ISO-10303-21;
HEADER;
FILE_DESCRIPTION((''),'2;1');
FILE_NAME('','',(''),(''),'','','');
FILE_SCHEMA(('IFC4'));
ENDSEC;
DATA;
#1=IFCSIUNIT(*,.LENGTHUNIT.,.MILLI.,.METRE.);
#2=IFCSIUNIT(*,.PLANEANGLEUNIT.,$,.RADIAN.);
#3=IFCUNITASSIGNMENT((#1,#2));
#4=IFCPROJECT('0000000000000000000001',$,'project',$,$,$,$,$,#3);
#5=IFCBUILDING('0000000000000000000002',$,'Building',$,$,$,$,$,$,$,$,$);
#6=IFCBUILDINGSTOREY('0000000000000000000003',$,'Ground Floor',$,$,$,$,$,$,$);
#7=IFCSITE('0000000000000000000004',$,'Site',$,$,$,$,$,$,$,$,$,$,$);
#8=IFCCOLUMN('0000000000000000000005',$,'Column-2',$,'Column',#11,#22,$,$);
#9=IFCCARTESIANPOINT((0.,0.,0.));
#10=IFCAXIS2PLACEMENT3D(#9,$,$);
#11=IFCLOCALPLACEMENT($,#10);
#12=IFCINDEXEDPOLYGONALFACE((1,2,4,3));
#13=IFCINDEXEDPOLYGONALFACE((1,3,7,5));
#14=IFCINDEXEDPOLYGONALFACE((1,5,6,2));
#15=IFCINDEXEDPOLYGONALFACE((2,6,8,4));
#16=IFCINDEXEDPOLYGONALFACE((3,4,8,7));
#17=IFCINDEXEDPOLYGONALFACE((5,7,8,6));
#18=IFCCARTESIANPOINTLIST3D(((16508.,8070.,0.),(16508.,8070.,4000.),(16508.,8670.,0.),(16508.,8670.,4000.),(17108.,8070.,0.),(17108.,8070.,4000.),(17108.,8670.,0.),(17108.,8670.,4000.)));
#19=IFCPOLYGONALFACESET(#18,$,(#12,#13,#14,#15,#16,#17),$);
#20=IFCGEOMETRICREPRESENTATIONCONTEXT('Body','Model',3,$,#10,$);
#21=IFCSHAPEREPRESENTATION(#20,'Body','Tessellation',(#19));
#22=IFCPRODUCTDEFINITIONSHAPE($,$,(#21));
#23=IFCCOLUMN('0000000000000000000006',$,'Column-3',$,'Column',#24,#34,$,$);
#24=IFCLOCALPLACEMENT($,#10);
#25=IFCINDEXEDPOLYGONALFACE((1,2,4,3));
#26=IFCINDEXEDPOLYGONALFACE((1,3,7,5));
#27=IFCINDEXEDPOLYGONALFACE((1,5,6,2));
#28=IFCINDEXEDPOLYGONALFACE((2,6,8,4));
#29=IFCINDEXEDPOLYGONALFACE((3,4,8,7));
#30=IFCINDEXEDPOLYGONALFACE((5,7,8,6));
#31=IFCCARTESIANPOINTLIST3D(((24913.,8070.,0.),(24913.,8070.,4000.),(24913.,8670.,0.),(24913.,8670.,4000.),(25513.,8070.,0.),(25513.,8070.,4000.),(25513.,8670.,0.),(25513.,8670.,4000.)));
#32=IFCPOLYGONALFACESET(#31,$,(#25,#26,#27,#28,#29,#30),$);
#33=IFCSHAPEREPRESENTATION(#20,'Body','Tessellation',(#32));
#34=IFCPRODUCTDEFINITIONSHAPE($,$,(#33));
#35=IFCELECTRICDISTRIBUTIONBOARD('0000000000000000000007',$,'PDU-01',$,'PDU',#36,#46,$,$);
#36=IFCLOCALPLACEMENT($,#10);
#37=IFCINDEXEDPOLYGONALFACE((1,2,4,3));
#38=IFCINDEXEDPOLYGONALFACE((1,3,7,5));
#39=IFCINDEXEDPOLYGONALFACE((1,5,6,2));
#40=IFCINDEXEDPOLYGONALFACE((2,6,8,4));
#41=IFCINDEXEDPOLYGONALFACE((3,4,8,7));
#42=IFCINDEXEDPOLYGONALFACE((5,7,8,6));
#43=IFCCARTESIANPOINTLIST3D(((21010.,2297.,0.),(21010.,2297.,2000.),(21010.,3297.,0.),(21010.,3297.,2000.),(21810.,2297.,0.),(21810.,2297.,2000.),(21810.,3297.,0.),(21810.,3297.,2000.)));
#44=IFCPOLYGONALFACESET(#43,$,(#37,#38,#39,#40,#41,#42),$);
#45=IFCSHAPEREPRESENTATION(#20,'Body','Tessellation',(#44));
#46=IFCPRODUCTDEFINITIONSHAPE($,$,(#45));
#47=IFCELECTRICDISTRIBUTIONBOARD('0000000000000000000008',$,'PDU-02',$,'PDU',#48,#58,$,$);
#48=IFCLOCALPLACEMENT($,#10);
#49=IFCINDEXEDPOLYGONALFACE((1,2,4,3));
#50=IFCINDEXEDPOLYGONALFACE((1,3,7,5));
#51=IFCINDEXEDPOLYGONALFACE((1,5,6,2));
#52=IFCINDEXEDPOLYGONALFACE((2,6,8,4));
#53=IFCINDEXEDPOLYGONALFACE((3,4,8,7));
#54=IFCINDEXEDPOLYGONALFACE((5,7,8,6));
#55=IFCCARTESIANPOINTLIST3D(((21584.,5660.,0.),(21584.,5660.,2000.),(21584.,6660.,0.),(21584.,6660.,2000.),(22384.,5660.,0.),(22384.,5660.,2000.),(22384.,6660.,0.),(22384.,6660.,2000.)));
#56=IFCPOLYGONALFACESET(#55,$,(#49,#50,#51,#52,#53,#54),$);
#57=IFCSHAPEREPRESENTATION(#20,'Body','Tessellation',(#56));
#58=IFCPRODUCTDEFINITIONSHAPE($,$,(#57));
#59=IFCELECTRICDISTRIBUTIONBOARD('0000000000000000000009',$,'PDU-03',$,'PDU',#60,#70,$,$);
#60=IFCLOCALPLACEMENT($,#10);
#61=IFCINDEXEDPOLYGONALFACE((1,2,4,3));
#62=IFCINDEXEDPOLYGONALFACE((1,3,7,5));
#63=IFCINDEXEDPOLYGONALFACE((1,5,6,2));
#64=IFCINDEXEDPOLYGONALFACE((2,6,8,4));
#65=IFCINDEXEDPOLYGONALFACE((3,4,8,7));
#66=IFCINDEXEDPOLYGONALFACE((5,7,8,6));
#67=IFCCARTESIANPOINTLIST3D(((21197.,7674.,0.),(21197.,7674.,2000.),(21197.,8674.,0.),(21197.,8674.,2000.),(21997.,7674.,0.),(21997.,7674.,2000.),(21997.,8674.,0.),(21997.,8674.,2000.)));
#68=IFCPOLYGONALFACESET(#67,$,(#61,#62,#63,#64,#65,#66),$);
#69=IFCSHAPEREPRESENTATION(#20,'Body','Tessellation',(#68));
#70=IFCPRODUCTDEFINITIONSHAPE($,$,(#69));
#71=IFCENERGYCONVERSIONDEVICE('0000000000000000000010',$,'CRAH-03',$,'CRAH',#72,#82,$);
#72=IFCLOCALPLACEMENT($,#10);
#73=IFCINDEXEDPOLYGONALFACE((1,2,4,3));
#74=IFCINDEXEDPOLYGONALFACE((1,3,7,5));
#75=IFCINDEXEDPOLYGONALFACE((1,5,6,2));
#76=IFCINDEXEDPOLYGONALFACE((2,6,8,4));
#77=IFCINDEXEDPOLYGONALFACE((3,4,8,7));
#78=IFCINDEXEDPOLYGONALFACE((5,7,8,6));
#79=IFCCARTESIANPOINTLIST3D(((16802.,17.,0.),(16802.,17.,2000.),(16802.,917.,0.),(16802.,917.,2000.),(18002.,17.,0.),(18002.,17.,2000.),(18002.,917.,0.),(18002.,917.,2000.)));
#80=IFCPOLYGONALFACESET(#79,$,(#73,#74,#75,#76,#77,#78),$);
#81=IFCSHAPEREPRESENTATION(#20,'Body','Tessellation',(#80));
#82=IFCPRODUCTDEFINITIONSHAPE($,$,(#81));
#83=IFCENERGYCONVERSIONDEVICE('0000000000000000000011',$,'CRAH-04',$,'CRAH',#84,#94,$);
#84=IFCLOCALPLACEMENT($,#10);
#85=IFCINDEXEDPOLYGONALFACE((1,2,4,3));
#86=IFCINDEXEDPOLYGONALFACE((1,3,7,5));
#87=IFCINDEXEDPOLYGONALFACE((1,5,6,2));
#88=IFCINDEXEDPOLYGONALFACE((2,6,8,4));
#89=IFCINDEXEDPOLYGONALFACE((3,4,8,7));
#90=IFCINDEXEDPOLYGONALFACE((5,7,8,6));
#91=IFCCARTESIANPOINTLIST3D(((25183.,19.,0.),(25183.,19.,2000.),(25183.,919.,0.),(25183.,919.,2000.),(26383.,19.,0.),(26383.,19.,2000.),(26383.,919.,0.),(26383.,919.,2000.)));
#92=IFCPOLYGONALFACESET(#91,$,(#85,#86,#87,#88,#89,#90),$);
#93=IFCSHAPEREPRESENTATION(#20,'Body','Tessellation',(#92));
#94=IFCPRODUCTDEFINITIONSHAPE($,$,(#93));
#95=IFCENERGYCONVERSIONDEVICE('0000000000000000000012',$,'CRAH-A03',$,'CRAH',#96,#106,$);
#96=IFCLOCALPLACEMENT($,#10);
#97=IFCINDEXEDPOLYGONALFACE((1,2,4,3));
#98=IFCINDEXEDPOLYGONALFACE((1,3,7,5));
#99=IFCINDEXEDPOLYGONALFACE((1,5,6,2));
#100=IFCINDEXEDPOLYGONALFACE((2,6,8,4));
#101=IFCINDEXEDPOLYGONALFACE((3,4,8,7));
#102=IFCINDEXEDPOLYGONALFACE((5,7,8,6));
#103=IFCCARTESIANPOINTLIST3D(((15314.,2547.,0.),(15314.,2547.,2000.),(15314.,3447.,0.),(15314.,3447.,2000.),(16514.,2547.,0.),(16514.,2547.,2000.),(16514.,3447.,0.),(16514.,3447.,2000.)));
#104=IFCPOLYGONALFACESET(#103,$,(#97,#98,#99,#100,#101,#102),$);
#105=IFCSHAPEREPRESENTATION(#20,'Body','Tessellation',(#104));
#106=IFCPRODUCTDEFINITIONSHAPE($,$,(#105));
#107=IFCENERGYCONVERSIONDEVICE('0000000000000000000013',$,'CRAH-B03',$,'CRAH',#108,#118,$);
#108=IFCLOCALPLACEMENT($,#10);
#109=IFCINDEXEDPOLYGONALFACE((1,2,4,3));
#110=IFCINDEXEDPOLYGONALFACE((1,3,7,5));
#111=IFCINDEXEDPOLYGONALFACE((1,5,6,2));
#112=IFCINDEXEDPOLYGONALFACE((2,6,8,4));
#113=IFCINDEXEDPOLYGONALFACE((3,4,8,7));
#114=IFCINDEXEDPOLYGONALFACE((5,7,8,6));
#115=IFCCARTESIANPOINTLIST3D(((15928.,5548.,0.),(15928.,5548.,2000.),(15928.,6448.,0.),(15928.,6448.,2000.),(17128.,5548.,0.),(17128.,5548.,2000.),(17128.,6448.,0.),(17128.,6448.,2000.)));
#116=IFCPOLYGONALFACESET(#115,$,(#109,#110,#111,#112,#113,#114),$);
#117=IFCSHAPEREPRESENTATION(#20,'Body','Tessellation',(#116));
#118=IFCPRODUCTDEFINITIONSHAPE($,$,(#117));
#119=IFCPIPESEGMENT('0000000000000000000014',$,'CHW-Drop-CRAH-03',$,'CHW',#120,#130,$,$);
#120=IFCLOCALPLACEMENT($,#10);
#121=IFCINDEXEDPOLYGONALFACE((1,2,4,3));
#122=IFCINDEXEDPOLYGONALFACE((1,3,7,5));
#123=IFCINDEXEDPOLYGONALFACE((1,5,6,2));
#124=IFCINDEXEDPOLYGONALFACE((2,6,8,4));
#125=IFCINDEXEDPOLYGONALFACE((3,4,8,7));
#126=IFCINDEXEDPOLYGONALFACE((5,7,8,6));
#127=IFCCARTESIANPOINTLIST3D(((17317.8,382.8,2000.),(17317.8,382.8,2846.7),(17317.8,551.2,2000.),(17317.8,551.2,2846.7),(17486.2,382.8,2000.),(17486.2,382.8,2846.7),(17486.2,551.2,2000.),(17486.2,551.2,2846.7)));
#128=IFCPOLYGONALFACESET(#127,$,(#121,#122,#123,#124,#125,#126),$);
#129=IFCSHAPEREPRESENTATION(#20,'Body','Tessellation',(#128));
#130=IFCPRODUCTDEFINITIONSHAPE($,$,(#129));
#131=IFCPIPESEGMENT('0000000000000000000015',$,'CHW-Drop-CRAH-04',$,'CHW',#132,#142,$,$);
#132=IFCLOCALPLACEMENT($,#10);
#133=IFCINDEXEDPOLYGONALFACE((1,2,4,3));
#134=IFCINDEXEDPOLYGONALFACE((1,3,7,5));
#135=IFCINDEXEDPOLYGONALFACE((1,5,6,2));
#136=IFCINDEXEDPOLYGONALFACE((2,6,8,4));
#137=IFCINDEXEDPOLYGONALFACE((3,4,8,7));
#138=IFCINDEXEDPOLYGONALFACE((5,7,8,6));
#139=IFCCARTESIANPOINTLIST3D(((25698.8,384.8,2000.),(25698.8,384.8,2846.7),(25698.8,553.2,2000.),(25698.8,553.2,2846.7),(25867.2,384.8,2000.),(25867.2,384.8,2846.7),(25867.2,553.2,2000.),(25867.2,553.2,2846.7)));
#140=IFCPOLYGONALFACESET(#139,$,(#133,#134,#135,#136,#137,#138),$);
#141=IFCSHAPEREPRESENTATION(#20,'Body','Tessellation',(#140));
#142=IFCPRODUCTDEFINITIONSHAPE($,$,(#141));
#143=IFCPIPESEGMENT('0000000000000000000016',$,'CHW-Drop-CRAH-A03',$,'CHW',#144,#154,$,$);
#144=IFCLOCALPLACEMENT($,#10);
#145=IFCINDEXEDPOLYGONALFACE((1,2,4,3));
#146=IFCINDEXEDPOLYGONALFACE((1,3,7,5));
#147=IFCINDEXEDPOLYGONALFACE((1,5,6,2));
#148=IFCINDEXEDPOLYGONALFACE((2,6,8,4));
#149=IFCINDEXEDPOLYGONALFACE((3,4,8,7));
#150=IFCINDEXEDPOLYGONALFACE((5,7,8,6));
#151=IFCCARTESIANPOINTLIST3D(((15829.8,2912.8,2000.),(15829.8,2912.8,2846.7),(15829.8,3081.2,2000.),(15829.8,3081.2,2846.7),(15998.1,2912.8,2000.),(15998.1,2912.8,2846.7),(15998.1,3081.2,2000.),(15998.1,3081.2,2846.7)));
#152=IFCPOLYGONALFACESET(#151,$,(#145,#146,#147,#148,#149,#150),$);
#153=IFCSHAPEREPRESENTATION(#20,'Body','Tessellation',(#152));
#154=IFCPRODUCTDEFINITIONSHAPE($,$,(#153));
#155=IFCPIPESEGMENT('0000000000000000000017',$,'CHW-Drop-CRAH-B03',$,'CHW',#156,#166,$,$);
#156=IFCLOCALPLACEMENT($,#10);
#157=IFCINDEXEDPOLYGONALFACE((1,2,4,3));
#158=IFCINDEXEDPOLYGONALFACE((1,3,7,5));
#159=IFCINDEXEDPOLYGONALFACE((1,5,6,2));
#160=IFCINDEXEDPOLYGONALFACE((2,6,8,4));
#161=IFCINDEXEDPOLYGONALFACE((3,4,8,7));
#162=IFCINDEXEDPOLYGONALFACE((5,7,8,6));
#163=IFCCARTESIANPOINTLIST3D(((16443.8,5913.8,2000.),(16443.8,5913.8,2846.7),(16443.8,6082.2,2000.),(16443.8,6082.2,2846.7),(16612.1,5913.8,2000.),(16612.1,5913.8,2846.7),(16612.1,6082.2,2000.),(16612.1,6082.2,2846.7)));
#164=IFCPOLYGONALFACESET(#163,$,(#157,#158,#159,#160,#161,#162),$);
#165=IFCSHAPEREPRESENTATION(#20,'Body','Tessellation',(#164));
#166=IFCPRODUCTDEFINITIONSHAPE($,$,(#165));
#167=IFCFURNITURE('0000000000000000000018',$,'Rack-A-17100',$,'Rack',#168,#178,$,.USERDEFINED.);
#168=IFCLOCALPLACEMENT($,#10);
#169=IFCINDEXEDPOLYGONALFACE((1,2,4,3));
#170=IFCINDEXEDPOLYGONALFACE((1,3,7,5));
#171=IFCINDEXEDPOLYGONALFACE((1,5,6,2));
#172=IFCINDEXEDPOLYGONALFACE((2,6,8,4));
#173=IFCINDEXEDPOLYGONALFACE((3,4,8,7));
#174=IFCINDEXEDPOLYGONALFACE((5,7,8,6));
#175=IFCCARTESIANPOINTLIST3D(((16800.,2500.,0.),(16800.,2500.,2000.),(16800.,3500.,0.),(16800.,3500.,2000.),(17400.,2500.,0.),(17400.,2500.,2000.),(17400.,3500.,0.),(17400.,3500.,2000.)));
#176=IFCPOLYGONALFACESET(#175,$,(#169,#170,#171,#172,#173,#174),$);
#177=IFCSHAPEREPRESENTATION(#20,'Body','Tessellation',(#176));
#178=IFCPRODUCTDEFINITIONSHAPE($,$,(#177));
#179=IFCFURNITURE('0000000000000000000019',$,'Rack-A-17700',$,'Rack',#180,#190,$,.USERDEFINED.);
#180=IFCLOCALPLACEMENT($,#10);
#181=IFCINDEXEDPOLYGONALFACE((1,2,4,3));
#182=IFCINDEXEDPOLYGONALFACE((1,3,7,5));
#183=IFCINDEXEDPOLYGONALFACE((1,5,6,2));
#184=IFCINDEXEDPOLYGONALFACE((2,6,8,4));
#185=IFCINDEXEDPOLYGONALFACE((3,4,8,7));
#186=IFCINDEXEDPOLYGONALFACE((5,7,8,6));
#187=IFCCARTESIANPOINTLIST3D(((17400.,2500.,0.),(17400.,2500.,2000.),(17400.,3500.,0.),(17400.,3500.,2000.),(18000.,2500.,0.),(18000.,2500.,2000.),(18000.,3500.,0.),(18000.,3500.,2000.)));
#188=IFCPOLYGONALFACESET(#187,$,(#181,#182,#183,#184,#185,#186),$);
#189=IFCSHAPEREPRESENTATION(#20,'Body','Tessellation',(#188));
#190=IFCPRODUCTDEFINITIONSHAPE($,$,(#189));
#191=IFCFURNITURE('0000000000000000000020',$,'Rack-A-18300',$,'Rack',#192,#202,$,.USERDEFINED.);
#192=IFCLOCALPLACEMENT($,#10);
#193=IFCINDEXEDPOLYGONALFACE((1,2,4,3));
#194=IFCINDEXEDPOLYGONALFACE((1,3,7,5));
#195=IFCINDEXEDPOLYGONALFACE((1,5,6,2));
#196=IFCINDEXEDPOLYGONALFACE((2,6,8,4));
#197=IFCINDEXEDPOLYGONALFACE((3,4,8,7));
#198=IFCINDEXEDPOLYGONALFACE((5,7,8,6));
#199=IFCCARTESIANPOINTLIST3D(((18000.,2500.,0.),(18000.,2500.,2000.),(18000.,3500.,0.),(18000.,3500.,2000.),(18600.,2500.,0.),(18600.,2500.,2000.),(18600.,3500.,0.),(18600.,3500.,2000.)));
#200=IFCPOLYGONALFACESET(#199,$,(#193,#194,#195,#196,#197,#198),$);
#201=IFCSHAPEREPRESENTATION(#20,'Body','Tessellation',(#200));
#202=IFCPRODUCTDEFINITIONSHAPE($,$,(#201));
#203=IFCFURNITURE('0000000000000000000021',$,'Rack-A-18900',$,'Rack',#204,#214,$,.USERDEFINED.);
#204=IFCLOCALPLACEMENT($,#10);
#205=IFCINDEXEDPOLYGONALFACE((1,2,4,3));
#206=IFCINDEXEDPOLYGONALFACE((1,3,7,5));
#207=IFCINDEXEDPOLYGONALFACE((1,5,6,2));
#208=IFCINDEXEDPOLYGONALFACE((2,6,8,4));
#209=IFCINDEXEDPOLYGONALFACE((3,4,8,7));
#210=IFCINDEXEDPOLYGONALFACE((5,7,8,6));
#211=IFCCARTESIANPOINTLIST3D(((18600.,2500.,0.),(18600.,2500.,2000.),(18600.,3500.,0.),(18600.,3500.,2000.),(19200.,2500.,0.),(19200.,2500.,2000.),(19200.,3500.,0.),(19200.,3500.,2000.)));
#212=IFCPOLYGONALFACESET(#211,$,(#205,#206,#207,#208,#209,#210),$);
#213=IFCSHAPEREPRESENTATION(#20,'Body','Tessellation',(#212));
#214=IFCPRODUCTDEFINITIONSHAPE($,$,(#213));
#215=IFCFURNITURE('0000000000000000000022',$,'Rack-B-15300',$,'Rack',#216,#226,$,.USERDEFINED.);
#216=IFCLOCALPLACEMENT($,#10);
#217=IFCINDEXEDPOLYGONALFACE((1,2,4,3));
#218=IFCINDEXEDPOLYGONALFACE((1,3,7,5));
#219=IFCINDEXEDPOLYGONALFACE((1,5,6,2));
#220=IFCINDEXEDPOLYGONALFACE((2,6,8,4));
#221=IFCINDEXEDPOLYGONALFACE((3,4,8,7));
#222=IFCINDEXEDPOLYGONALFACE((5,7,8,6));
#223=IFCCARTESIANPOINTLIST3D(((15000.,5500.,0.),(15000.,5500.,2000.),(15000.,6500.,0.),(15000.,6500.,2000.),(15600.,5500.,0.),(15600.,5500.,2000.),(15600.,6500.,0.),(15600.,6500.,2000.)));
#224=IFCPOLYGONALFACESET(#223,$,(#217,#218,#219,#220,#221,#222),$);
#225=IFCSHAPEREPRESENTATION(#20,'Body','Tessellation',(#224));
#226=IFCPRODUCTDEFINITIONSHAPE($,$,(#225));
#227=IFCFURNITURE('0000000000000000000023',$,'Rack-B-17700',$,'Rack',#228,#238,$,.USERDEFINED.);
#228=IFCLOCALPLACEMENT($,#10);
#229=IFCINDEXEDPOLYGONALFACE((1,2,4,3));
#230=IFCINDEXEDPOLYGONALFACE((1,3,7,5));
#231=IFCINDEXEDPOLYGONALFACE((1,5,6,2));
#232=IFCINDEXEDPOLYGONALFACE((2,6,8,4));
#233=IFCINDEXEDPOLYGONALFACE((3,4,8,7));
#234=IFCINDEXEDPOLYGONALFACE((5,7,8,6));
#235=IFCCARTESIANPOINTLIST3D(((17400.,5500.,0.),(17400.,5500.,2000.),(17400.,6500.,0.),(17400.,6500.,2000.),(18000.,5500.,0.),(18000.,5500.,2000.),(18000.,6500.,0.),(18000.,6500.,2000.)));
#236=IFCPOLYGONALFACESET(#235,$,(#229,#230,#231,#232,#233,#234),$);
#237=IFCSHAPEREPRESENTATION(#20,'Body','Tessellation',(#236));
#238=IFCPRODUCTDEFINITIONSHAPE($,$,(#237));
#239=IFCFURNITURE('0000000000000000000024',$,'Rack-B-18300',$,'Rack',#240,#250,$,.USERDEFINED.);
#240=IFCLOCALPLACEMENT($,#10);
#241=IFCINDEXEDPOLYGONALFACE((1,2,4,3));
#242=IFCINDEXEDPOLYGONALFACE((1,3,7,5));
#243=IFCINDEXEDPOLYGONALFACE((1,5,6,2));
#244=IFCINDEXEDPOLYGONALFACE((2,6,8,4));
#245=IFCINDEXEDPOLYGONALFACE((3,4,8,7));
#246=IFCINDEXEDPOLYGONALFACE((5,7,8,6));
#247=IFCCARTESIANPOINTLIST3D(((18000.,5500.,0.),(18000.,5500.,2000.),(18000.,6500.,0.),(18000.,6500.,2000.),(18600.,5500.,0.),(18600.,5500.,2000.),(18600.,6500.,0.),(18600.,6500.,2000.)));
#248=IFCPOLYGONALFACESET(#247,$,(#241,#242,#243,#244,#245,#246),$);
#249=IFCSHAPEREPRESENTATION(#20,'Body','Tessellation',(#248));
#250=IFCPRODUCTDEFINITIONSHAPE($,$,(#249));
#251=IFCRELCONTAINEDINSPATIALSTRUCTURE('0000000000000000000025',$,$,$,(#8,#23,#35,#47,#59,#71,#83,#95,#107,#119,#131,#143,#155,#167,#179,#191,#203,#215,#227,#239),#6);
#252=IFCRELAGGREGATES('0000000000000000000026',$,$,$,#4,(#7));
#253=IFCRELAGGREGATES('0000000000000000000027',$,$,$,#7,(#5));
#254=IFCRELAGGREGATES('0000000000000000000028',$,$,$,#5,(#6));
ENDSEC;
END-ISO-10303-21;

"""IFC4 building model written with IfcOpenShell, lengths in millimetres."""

from ifc_helpers import new_model, si_unit, frame, origin, place, context, project, spatial, rectangle, extrude, element, save


model = new_model("IFC4")

# Units and contexts
model_context = context("Model", 3, world=origin(), identifier="Body")
ifc_project = project(units=[si_unit("LENGTHUNIT", "METRE", prefix="MILLI"), si_unit("PLANEANGLEUNIT", "RADIAN")])

# Site, building, storey
site = spatial("IfcSite", under=ifc_project, Name="Site")
building = spatial("IfcBuilding", under=site, Name="Building")
storey = spatial("IfcBuildingStorey", under=building, Name="Ground Floor")

# Columns
for number, where, z_axis, x_axis, name in (
    (1, (16808.0, 8370.0, 0.0), (0.0, 0.0, 1.0), (1.0, 0.0, 0.0), "Column-2"),
    (2, (25213.0, 8370.0, 0.0), (0.0, 0.0, 1.0), (1.0, 0.0, 0.0), "Column-3"),
):
    element("IfcColumn", number, at=place(None, frame(where, z_axis=z_axis, x_axis=x_axis)), inside=storey, Name=name, ObjectType="Column", context=model_context, shape_type="SweptSolid", body=[
        extrude(rectangle(XDim=600.0, YDim=600.0), origin(), (0.0, 0.0, 1.0), 4000.0),
    ])

# Electric distribution boards
for number, where, z_axis, x_axis, name in (
    (3, (21410.0, 2797.0, 0.0), (0.0, 0.0, 1.0), (1.0, 0.0, 0.0), "PDU-01"),
    (4, (21984.0, 6160.0, 0.0), (0.0, 0.0, 1.0), (1.0, 0.0, 0.0), "PDU-02"),
    (5, (21597.0, 8174.0, 0.0), (0.0, 0.0, 1.0), (1.0, 0.0, 0.0), "PDU-03"),
):
    element("IfcElectricDistributionBoard", number, at=place(None, frame(where, z_axis=z_axis, x_axis=x_axis)), inside=storey, Name=name, ObjectType="PDU", context=model_context, shape_type="SweptSolid", body=[
        extrude(rectangle(XDim=800.0, YDim=1000.0), origin(), (0.0, 0.0, 1.0), 2000.0),
    ])

# Energy conversion devices
for number, where, z_axis, x_axis, name in (
    (6, (17402.0, 467.0, 0.0), (0.0, 0.0, 1.0), (1.0, 0.0, 0.0), "CRAH-03"),
    (7, (25783.0, 469.0, 0.0), (0.0, 0.0, 1.0), (1.0, 0.0, 0.0), "CRAH-04"),
    (8, (15914.0, 2997.0, 0.0), (0.0, 0.0, 1.0), (1.0, 0.0, 0.0), "CRAH-A03"),
    (9, (16528.0, 5998.0, 0.0), (0.0, 0.0, 1.0), (1.0, 0.0, 0.0), "CRAH-B03"),
):
    element("IfcEnergyConversionDevice", number, at=place(None, frame(where, z_axis=z_axis, x_axis=x_axis)), inside=storey, Name=name, ObjectType="CRAH", context=model_context, shape_type="SweptSolid", body=[
        extrude(rectangle(XDim=1200.0, YDim=900.0), origin(), (0.0, 0.0, 1.0), 2000.0),
    ])

# Pipe segments
for number, where, z_axis, x_axis, name in (
    (10, (17402.0, 467.0, 2000.0), (0.0, 0.0, 1.0), (1.0, 0.0, 0.0), "CHW-Drop-CRAH-03"),
    (11, (25783.0, 469.0, 2000.0), (0.0, 0.0, 1.0), (1.0, 0.0, 0.0), "CHW-Drop-CRAH-04"),
    (12, (15914.0, 2997.0, 2000.0), (0.0, 0.0, 1.0), (1.0, 0.0, 0.0), "CHW-Drop-CRAH-A03"),
    (13, (16528.0, 5998.0, 2000.0), (0.0, 0.0, 1.0), (1.0, 0.0, 0.0), "CHW-Drop-CRAH-B03"),
):
    element("IfcPipeSegment", number, at=place(None, frame(where, z_axis=z_axis, x_axis=x_axis)), inside=storey, Name=name, ObjectType="CHW", context=model_context, shape_type="SweptSolid", body=[
        extrude(rectangle(XDim=168.3, YDim=168.3), origin(), (0.0, 0.0, 1.0), 846.7),
    ])

# Furniture
for number, where, z_axis, x_axis, name in (
    (14, (17100.0, 3000.0, 0.0), (0.0, 0.0, 1.0), (1.0, 0.0, 0.0), "Rack-A-17100"),
    (15, (17700.0, 3000.0, 0.0), (0.0, 0.0, 1.0), (1.0, 0.0, 0.0), "Rack-A-17700"),
    (16, (18300.0, 3000.0, 0.0), (0.0, 0.0, 1.0), (1.0, 0.0, 0.0), "Rack-A-18300"),
    (17, (18900.0, 3000.0, 0.0), (0.0, 0.0, 1.0), (1.0, 0.0, 0.0), "Rack-A-18900"),
    (18, (15300.0, 6000.0, 0.0), (0.0, 0.0, 1.0), (1.0, 0.0, 0.0), "Rack-B-15300"),
    (19, (17700.0, 6000.0, 0.0), (0.0, 0.0, 1.0), (1.0, 0.0, 0.0), "Rack-B-17700"),
    (20, (18300.0, 6000.0, 0.0), (0.0, 0.0, 1.0), (1.0, 0.0, 0.0), "Rack-B-18300"),
):
    element("IfcFurniture", number, at=place(None, frame(where, z_axis=z_axis, x_axis=x_axis)), inside=storey, Name=name, ObjectType="Rack", PredefinedType="USERDEFINED", context=model_context, shape_type="SweptSolid", body=[
        extrude(rectangle(XDim=600.0, YDim=1000.0), origin(), (0.0, 0.0, 1.0), 2000.0),
    ])

save(model, "model.ifc")
